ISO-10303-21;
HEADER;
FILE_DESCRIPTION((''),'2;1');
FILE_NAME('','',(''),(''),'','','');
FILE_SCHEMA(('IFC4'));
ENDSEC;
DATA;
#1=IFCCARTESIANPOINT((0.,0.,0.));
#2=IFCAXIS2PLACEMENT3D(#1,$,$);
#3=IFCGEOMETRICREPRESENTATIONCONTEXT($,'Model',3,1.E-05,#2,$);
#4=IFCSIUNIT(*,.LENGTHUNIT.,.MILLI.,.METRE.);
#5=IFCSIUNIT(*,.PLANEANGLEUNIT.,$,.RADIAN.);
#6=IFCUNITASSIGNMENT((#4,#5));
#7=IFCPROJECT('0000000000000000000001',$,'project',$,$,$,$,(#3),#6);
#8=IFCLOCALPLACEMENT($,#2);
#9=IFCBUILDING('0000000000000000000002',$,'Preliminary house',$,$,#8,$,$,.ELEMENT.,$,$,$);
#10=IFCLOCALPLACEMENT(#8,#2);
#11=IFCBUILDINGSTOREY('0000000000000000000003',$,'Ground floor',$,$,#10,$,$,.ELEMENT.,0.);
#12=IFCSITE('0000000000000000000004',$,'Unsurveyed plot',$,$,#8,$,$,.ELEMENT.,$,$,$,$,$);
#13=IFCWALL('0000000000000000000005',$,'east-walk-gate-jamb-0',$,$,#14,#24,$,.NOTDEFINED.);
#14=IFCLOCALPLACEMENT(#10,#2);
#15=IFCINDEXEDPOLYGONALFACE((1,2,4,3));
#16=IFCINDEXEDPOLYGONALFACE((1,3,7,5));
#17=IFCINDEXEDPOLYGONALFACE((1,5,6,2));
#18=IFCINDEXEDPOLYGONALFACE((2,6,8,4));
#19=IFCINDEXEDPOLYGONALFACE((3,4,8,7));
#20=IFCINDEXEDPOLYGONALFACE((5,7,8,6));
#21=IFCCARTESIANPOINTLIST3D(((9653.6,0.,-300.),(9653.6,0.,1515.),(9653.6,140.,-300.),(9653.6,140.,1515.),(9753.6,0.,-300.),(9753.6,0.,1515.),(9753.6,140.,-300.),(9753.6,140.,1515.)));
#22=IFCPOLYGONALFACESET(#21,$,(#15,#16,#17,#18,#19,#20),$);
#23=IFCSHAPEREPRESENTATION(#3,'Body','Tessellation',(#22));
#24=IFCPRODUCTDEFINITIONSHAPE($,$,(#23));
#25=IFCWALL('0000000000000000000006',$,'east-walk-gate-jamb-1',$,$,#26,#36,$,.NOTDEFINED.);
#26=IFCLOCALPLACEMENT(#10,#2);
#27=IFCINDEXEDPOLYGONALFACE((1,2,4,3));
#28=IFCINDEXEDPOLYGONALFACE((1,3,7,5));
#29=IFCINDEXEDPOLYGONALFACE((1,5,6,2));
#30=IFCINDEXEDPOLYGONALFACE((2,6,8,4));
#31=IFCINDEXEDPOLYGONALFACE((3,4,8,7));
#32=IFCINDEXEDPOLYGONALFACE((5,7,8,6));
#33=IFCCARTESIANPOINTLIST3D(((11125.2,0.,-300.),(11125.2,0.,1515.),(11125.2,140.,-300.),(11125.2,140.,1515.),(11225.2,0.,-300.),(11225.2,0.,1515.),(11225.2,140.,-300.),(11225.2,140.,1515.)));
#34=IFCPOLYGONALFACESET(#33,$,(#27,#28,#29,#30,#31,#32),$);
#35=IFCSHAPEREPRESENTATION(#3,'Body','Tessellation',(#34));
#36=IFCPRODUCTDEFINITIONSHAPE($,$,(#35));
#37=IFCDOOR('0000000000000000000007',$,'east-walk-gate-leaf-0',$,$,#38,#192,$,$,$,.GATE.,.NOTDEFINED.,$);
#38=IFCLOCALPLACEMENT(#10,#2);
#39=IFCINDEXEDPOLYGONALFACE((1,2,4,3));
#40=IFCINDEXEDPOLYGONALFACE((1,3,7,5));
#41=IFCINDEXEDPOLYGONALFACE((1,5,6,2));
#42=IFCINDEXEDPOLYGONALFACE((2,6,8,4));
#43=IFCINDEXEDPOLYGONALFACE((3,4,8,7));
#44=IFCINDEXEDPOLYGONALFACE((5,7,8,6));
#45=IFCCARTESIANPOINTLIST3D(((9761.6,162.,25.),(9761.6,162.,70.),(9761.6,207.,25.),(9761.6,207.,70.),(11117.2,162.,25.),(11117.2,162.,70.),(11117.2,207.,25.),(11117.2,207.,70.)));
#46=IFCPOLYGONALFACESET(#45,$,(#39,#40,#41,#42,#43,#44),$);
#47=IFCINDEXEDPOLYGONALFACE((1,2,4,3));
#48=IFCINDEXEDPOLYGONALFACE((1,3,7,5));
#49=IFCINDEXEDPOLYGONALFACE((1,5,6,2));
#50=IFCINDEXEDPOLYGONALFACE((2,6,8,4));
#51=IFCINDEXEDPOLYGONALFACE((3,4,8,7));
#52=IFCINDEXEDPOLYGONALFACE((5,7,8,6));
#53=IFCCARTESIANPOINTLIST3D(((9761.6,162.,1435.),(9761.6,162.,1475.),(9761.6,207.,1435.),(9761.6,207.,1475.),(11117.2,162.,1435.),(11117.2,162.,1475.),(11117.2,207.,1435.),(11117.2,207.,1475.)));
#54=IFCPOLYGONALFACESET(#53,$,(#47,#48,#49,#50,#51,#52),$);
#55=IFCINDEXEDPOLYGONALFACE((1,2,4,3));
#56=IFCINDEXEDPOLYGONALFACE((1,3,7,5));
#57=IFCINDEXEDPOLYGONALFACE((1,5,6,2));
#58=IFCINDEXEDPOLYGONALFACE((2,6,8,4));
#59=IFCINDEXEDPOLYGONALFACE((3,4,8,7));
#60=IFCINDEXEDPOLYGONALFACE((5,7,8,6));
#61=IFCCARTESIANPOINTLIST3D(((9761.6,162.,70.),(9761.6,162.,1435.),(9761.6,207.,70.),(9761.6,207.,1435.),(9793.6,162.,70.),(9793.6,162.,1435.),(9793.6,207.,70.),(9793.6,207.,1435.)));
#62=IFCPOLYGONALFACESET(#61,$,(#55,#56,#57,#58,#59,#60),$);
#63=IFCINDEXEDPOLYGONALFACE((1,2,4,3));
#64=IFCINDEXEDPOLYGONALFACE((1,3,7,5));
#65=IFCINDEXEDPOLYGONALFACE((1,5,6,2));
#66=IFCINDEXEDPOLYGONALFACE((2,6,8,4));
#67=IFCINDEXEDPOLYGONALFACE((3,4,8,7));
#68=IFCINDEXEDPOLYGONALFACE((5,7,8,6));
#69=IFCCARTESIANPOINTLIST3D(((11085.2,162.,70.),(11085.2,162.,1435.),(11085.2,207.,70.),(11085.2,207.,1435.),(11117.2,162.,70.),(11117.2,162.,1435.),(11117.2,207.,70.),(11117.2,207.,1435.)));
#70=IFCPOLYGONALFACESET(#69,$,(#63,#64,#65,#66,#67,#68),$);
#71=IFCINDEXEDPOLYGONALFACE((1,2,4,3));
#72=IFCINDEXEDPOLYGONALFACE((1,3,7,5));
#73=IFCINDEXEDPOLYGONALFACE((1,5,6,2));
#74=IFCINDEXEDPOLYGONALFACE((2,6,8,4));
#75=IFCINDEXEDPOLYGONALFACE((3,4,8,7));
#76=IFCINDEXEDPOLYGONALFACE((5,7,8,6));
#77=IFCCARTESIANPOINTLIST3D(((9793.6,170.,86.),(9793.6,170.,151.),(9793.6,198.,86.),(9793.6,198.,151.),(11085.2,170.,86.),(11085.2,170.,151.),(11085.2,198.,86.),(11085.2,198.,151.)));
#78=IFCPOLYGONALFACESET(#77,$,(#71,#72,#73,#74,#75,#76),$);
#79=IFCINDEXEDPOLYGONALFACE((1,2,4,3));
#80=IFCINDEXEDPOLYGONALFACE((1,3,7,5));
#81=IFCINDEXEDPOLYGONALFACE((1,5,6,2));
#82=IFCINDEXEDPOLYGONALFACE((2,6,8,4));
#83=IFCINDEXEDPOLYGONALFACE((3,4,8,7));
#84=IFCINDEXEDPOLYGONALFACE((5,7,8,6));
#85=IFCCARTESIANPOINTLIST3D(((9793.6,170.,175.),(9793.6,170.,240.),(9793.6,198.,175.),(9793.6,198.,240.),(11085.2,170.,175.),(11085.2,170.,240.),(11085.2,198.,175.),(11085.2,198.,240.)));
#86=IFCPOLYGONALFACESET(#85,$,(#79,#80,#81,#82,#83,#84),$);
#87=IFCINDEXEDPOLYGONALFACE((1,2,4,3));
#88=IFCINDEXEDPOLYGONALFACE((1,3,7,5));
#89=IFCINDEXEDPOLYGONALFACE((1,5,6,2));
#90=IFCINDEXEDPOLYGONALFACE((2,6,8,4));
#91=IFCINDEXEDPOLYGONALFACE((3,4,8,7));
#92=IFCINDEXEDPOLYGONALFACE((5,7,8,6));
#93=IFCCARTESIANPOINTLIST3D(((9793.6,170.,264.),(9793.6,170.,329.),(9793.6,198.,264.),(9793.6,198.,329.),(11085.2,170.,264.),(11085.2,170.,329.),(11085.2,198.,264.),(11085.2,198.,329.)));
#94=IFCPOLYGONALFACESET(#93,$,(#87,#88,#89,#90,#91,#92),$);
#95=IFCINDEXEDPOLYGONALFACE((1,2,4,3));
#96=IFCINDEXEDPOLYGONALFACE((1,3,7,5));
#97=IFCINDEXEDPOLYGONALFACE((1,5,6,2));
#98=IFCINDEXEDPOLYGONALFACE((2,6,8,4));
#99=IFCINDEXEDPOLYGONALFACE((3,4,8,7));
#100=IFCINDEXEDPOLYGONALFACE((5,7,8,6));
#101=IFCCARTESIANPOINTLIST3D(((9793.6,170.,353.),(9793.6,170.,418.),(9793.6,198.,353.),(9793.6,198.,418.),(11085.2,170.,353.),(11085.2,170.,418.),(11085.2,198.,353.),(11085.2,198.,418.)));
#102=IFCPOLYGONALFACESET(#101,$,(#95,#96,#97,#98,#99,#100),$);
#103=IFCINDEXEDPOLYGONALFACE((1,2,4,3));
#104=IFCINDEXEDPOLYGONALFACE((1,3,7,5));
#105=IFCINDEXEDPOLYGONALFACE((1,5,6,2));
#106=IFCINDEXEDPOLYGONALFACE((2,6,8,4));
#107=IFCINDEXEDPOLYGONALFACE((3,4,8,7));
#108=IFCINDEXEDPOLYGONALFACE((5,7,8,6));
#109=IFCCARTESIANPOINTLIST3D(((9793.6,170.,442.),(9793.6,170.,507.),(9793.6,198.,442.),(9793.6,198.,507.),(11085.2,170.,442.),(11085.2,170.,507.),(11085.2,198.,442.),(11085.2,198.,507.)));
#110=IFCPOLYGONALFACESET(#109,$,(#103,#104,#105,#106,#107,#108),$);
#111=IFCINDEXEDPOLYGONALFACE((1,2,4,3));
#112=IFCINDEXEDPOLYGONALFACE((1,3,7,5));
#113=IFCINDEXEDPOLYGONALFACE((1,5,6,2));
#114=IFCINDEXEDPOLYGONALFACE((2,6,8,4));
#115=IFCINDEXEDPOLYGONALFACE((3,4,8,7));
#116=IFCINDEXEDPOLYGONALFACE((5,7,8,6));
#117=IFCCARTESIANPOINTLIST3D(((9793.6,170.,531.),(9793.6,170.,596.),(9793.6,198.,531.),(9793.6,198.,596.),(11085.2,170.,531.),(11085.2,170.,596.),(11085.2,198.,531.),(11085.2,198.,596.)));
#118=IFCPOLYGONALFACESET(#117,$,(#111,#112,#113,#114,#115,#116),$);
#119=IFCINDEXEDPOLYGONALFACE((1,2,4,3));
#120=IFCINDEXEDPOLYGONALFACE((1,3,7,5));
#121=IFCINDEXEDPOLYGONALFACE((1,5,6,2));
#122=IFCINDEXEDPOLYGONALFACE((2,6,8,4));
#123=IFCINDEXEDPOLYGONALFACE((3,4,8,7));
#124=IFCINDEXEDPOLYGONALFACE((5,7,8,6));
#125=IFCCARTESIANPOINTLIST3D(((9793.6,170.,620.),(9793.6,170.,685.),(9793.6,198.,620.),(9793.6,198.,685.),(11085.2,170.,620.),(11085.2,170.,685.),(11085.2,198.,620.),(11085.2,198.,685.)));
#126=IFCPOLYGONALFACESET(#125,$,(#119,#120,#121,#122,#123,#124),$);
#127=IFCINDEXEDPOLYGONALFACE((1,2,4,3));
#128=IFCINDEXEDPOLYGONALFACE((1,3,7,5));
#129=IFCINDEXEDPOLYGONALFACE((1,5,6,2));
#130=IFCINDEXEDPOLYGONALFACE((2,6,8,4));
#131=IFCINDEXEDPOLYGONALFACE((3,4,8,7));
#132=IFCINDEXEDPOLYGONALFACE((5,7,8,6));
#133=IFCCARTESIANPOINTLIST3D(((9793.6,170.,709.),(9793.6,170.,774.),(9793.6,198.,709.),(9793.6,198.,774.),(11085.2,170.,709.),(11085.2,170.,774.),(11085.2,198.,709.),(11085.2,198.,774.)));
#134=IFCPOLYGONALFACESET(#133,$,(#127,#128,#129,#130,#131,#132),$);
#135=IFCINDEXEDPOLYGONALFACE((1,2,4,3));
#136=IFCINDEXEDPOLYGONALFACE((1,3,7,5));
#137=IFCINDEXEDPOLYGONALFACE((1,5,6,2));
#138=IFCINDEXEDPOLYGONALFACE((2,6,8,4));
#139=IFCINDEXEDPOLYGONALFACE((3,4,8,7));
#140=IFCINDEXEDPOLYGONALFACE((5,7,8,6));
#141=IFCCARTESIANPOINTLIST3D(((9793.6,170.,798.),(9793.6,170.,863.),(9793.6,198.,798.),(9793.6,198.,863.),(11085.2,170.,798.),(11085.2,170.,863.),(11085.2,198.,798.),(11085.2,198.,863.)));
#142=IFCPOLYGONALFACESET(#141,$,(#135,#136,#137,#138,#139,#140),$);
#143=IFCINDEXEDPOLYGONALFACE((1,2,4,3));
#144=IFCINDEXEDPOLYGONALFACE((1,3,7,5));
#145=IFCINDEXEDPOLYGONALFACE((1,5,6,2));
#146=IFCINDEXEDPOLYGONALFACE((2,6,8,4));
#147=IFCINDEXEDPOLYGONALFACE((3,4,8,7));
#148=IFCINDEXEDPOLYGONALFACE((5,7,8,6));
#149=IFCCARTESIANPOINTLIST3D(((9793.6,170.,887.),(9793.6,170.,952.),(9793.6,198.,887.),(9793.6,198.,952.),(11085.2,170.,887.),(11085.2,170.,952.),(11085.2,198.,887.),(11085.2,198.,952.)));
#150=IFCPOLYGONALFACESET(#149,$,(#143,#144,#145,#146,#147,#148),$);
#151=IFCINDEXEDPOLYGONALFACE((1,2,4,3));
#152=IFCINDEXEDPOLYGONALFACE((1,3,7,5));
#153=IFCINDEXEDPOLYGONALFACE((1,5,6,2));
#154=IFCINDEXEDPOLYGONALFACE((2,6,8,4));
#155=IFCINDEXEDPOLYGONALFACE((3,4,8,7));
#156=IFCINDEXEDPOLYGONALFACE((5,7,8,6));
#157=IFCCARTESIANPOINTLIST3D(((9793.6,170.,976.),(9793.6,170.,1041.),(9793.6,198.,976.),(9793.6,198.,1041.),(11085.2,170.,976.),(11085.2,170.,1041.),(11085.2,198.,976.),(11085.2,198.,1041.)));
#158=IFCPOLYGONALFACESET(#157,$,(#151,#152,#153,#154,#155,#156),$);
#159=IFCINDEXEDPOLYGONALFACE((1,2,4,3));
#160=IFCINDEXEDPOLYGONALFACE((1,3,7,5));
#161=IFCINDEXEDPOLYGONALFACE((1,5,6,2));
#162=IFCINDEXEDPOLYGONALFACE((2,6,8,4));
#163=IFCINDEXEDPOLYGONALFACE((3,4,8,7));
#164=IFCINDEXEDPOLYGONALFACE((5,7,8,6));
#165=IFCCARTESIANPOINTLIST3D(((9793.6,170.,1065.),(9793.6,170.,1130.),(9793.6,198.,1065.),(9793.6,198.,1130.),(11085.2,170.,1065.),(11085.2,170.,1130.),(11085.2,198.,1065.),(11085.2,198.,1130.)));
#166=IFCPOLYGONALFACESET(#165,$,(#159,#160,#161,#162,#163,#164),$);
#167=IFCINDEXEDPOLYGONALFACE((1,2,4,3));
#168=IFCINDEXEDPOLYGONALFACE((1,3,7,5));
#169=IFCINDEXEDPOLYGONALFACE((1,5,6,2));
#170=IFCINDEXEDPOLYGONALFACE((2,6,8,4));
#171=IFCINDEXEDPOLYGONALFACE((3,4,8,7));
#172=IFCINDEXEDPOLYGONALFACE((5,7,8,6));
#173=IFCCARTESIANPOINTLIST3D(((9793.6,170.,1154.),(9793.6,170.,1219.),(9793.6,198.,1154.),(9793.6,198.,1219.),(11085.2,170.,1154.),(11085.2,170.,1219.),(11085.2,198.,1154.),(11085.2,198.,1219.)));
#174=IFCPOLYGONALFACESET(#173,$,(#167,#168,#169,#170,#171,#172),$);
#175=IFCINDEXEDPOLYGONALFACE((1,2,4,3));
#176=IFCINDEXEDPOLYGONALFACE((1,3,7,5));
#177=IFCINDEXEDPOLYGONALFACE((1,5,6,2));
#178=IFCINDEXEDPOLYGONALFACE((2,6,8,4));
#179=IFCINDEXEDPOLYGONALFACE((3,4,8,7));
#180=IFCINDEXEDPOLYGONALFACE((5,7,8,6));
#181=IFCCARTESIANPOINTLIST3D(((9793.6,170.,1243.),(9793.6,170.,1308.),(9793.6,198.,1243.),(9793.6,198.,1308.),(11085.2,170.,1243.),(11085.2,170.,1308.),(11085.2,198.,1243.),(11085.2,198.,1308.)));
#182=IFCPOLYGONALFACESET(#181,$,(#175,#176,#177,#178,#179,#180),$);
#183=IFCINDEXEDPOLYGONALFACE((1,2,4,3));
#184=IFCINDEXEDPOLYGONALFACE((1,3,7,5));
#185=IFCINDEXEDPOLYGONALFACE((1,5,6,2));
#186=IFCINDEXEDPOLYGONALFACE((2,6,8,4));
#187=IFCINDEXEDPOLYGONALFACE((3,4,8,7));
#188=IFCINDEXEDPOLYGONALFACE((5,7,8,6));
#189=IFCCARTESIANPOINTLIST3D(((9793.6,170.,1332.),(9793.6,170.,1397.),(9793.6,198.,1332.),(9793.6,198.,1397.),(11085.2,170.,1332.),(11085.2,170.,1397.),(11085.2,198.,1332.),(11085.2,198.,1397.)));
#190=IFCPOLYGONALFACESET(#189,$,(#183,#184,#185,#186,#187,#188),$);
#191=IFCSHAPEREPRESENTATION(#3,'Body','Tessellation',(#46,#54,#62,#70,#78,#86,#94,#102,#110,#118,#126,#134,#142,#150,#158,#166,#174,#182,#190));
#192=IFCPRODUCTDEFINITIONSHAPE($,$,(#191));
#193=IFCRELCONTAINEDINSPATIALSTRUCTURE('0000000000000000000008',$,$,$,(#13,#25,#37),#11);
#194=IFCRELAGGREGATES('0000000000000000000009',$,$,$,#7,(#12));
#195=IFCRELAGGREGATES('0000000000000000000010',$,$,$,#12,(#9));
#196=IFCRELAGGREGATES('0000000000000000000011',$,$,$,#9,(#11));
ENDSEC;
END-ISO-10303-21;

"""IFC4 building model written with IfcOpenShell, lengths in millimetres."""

from ifc_helpers import new_model, si_unit, frame, origin, place, context, project, spatial, polyline, outline, extrude, element, save


model = new_model("IFC4")

# Units and contexts
model_context = context("Model", 3, precision=1e-05, world=origin())
ifc_project = project(units=[si_unit("LENGTHUNIT", "METRE", prefix="MILLI"), si_unit("PLANEANGLEUNIT", "RADIAN")], contexts=[model_context])

# Site, building, storey
placement_1 = place(None, origin())
site = spatial("IfcSite", under=ifc_project, at=placement_1, Name="Unsurveyed plot", CompositionType="ELEMENT")
building = spatial("IfcBuilding", under=site, at=placement_1, Name="Preliminary house", CompositionType="ELEMENT")
placement_2 = place(placement_1, origin())
storey = spatial("IfcBuildingStorey", under=building, at=placement_2, Name="Ground floor", CompositionType="ELEMENT", Elevation=0.0)

# Walls
element("IfcWall", 1, at=placement_2, inside=storey, Name="east-walk-gate-jamb-0", PredefinedType="NOTDEFINED", context=model_context, shape_type="SweptSolid", body=[
    extrude(outline(polyline([(9753.6, 0.0), (9753.6, 140.0), (9653.6, 140.0), (9653.6, 0.0), (9753.6, 0.0)])), frame((0.0, 0.0, -300.0)), (0.0, 0.0, 1.0), 1815.0),
])
element("IfcWall", 2, at=placement_2, inside=storey, Name="east-walk-gate-jamb-1", PredefinedType="NOTDEFINED", context=model_context, shape_type="SweptSolid", body=[
    extrude(outline(polyline([(11225.2, 0.0), (11225.2, 140.0), (11125.2, 140.0), (11125.2, 0.0), (11225.2, 0.0)])), frame((0.0, 0.0, -300.0)), (0.0, 0.0, 1.0), 1815.0),
])

# Door
element("IfcDoor", 3, at=placement_2, inside=storey, Name="east-walk-gate-leaf-0", OperationType="NOTDEFINED", PredefinedType="GATE", context=model_context, shape_type="SweptSolid", body=[
    extrude(outline(polyline([(11117.2, 162.0), (11117.2, 207.0), (9761.6, 207.0), (9761.6, 162.0), (11117.2, 162.0)])), frame((0.0, 0.0, 25.0)), (0.0, 0.0, 1.0), 45.0),
    extrude(outline(polyline([(11117.2, 162.0), (11117.2, 207.0), (9761.6, 207.0), (9761.6, 162.0), (11117.2, 162.0)])), frame((0.0, 0.0, 1435.0)), (0.0, 0.0, 1.0), 40.0),
    extrude(outline(polyline([(9793.6, 162.0), (9793.6, 207.0), (9761.6, 207.0), (9761.6, 162.0), (9793.6, 162.0)])), frame((0.0, 0.0, 70.0)), (0.0, 0.0, 1.0), 1365.0),
    extrude(outline(polyline([(11117.2, 162.0), (11117.2, 207.0), (11085.2, 207.0), (11085.2, 162.0), (11117.2, 162.0)])), frame((0.0, 0.0, 70.0)), (0.0, 0.0, 1.0), 1365.0),
    extrude(outline(polyline([(11085.2, 170.0), (11085.2, 198.0), (9793.6, 198.0), (9793.6, 170.0), (11085.2, 170.0)])), frame((0.0, 0.0, 86.0)), (0.0, 0.0, 1.0), 65.0),
    extrude(outline(polyline([(11085.2, 170.0), (11085.2, 198.0), (9793.6, 198.0), (9793.6, 170.0), (11085.2, 170.0)])), frame((0.0, 0.0, 175.0)), (0.0, 0.0, 1.0), 65.0),
    extrude(outline(polyline([(11085.2, 170.0), (11085.2, 198.0), (9793.6, 198.0), (9793.6, 170.0), (11085.2, 170.0)])), frame((0.0, 0.0, 264.0)), (0.0, 0.0, 1.0), 65.0),
    extrude(outline(polyline([(11085.2, 170.0), (11085.2, 198.0), (9793.6, 198.0), (9793.6, 170.0), (11085.2, 170.0)])), frame((0.0, 0.0, 353.0)), (0.0, 0.0, 1.0), 65.0),
    extrude(outline(polyline([(11085.2, 170.0), (11085.2, 198.0), (9793.6, 198.0), (9793.6, 170.0), (11085.2, 170.0)])), frame((0.0, 0.0, 442.0)), (0.0, 0.0, 1.0), 65.0),
    extrude(outline(polyline([(11085.2, 170.0), (11085.2, 198.0), (9793.6, 198.0), (9793.6, 170.0), (11085.2, 170.0)])), frame((0.0, 0.0, 531.0)), (0.0, 0.0, 1.0), 65.0),
    extrude(outline(polyline([(11085.2, 170.0), (11085.2, 198.0), (9793.6, 198.0), (9793.6, 170.0), (11085.2, 170.0)])), frame((0.0, 0.0, 620.0)), (0.0, 0.0, 1.0), 65.0),
    extrude(outline(polyline([(11085.2, 170.0), (11085.2, 198.0), (9793.6, 198.0), (9793.6, 170.0), (11085.2, 170.0)])), frame((0.0, 0.0, 709.0)), (0.0, 0.0, 1.0), 65.0),
    extrude(outline(polyline([(11085.2, 170.0), (11085.2, 198.0), (9793.6, 198.0), (9793.6, 170.0), (11085.2, 170.0)])), frame((0.0, 0.0, 798.0)), (0.0, 0.0, 1.0), 65.0),
    extrude(outline(polyline([(11085.2, 170.0), (11085.2, 198.0), (9793.6, 198.0), (9793.6, 170.0), (11085.2, 170.0)])), frame((0.0, 0.0, 887.0)), (0.0, 0.0, 1.0), 65.0),
    extrude(outline(polyline([(11085.2, 170.0), (11085.2, 198.0), (9793.6, 198.0), (9793.6, 170.0), (11085.2, 170.0)])), frame((0.0, 0.0, 976.0)), (0.0, 0.0, 1.0), 65.0),
    extrude(outline(polyline([(11085.2, 170.0), (11085.2, 198.0), (9793.6, 198.0), (9793.6, 170.0), (11085.2, 170.0)])), frame((0.0, 0.0, 1065.0)), (0.0, 0.0, 1.0), 65.0),
    extrude(outline(polyline([(11085.2, 170.0), (11085.2, 198.0), (9793.6, 198.0), (9793.6, 170.0), (11085.2, 170.0)])), frame((0.0, 0.0, 1154.0)), (0.0, 0.0, 1.0), 65.0),
    extrude(outline(polyline([(11085.2, 170.0), (11085.2, 198.0), (9793.6, 198.0), (9793.6, 170.0), (11085.2, 170.0)])), frame((0.0, 0.0, 1243.0)), (0.0, 0.0, 1.0), 65.0),
    extrude(outline(polyline([(11085.2, 170.0), (11085.2, 198.0), (9793.6, 198.0), (9793.6, 170.0), (11085.2, 170.0)])), frame((0.0, 0.0, 1332.0)), (0.0, 0.0, 1.0), 65.0),
])

save(model, "model.ifc")
